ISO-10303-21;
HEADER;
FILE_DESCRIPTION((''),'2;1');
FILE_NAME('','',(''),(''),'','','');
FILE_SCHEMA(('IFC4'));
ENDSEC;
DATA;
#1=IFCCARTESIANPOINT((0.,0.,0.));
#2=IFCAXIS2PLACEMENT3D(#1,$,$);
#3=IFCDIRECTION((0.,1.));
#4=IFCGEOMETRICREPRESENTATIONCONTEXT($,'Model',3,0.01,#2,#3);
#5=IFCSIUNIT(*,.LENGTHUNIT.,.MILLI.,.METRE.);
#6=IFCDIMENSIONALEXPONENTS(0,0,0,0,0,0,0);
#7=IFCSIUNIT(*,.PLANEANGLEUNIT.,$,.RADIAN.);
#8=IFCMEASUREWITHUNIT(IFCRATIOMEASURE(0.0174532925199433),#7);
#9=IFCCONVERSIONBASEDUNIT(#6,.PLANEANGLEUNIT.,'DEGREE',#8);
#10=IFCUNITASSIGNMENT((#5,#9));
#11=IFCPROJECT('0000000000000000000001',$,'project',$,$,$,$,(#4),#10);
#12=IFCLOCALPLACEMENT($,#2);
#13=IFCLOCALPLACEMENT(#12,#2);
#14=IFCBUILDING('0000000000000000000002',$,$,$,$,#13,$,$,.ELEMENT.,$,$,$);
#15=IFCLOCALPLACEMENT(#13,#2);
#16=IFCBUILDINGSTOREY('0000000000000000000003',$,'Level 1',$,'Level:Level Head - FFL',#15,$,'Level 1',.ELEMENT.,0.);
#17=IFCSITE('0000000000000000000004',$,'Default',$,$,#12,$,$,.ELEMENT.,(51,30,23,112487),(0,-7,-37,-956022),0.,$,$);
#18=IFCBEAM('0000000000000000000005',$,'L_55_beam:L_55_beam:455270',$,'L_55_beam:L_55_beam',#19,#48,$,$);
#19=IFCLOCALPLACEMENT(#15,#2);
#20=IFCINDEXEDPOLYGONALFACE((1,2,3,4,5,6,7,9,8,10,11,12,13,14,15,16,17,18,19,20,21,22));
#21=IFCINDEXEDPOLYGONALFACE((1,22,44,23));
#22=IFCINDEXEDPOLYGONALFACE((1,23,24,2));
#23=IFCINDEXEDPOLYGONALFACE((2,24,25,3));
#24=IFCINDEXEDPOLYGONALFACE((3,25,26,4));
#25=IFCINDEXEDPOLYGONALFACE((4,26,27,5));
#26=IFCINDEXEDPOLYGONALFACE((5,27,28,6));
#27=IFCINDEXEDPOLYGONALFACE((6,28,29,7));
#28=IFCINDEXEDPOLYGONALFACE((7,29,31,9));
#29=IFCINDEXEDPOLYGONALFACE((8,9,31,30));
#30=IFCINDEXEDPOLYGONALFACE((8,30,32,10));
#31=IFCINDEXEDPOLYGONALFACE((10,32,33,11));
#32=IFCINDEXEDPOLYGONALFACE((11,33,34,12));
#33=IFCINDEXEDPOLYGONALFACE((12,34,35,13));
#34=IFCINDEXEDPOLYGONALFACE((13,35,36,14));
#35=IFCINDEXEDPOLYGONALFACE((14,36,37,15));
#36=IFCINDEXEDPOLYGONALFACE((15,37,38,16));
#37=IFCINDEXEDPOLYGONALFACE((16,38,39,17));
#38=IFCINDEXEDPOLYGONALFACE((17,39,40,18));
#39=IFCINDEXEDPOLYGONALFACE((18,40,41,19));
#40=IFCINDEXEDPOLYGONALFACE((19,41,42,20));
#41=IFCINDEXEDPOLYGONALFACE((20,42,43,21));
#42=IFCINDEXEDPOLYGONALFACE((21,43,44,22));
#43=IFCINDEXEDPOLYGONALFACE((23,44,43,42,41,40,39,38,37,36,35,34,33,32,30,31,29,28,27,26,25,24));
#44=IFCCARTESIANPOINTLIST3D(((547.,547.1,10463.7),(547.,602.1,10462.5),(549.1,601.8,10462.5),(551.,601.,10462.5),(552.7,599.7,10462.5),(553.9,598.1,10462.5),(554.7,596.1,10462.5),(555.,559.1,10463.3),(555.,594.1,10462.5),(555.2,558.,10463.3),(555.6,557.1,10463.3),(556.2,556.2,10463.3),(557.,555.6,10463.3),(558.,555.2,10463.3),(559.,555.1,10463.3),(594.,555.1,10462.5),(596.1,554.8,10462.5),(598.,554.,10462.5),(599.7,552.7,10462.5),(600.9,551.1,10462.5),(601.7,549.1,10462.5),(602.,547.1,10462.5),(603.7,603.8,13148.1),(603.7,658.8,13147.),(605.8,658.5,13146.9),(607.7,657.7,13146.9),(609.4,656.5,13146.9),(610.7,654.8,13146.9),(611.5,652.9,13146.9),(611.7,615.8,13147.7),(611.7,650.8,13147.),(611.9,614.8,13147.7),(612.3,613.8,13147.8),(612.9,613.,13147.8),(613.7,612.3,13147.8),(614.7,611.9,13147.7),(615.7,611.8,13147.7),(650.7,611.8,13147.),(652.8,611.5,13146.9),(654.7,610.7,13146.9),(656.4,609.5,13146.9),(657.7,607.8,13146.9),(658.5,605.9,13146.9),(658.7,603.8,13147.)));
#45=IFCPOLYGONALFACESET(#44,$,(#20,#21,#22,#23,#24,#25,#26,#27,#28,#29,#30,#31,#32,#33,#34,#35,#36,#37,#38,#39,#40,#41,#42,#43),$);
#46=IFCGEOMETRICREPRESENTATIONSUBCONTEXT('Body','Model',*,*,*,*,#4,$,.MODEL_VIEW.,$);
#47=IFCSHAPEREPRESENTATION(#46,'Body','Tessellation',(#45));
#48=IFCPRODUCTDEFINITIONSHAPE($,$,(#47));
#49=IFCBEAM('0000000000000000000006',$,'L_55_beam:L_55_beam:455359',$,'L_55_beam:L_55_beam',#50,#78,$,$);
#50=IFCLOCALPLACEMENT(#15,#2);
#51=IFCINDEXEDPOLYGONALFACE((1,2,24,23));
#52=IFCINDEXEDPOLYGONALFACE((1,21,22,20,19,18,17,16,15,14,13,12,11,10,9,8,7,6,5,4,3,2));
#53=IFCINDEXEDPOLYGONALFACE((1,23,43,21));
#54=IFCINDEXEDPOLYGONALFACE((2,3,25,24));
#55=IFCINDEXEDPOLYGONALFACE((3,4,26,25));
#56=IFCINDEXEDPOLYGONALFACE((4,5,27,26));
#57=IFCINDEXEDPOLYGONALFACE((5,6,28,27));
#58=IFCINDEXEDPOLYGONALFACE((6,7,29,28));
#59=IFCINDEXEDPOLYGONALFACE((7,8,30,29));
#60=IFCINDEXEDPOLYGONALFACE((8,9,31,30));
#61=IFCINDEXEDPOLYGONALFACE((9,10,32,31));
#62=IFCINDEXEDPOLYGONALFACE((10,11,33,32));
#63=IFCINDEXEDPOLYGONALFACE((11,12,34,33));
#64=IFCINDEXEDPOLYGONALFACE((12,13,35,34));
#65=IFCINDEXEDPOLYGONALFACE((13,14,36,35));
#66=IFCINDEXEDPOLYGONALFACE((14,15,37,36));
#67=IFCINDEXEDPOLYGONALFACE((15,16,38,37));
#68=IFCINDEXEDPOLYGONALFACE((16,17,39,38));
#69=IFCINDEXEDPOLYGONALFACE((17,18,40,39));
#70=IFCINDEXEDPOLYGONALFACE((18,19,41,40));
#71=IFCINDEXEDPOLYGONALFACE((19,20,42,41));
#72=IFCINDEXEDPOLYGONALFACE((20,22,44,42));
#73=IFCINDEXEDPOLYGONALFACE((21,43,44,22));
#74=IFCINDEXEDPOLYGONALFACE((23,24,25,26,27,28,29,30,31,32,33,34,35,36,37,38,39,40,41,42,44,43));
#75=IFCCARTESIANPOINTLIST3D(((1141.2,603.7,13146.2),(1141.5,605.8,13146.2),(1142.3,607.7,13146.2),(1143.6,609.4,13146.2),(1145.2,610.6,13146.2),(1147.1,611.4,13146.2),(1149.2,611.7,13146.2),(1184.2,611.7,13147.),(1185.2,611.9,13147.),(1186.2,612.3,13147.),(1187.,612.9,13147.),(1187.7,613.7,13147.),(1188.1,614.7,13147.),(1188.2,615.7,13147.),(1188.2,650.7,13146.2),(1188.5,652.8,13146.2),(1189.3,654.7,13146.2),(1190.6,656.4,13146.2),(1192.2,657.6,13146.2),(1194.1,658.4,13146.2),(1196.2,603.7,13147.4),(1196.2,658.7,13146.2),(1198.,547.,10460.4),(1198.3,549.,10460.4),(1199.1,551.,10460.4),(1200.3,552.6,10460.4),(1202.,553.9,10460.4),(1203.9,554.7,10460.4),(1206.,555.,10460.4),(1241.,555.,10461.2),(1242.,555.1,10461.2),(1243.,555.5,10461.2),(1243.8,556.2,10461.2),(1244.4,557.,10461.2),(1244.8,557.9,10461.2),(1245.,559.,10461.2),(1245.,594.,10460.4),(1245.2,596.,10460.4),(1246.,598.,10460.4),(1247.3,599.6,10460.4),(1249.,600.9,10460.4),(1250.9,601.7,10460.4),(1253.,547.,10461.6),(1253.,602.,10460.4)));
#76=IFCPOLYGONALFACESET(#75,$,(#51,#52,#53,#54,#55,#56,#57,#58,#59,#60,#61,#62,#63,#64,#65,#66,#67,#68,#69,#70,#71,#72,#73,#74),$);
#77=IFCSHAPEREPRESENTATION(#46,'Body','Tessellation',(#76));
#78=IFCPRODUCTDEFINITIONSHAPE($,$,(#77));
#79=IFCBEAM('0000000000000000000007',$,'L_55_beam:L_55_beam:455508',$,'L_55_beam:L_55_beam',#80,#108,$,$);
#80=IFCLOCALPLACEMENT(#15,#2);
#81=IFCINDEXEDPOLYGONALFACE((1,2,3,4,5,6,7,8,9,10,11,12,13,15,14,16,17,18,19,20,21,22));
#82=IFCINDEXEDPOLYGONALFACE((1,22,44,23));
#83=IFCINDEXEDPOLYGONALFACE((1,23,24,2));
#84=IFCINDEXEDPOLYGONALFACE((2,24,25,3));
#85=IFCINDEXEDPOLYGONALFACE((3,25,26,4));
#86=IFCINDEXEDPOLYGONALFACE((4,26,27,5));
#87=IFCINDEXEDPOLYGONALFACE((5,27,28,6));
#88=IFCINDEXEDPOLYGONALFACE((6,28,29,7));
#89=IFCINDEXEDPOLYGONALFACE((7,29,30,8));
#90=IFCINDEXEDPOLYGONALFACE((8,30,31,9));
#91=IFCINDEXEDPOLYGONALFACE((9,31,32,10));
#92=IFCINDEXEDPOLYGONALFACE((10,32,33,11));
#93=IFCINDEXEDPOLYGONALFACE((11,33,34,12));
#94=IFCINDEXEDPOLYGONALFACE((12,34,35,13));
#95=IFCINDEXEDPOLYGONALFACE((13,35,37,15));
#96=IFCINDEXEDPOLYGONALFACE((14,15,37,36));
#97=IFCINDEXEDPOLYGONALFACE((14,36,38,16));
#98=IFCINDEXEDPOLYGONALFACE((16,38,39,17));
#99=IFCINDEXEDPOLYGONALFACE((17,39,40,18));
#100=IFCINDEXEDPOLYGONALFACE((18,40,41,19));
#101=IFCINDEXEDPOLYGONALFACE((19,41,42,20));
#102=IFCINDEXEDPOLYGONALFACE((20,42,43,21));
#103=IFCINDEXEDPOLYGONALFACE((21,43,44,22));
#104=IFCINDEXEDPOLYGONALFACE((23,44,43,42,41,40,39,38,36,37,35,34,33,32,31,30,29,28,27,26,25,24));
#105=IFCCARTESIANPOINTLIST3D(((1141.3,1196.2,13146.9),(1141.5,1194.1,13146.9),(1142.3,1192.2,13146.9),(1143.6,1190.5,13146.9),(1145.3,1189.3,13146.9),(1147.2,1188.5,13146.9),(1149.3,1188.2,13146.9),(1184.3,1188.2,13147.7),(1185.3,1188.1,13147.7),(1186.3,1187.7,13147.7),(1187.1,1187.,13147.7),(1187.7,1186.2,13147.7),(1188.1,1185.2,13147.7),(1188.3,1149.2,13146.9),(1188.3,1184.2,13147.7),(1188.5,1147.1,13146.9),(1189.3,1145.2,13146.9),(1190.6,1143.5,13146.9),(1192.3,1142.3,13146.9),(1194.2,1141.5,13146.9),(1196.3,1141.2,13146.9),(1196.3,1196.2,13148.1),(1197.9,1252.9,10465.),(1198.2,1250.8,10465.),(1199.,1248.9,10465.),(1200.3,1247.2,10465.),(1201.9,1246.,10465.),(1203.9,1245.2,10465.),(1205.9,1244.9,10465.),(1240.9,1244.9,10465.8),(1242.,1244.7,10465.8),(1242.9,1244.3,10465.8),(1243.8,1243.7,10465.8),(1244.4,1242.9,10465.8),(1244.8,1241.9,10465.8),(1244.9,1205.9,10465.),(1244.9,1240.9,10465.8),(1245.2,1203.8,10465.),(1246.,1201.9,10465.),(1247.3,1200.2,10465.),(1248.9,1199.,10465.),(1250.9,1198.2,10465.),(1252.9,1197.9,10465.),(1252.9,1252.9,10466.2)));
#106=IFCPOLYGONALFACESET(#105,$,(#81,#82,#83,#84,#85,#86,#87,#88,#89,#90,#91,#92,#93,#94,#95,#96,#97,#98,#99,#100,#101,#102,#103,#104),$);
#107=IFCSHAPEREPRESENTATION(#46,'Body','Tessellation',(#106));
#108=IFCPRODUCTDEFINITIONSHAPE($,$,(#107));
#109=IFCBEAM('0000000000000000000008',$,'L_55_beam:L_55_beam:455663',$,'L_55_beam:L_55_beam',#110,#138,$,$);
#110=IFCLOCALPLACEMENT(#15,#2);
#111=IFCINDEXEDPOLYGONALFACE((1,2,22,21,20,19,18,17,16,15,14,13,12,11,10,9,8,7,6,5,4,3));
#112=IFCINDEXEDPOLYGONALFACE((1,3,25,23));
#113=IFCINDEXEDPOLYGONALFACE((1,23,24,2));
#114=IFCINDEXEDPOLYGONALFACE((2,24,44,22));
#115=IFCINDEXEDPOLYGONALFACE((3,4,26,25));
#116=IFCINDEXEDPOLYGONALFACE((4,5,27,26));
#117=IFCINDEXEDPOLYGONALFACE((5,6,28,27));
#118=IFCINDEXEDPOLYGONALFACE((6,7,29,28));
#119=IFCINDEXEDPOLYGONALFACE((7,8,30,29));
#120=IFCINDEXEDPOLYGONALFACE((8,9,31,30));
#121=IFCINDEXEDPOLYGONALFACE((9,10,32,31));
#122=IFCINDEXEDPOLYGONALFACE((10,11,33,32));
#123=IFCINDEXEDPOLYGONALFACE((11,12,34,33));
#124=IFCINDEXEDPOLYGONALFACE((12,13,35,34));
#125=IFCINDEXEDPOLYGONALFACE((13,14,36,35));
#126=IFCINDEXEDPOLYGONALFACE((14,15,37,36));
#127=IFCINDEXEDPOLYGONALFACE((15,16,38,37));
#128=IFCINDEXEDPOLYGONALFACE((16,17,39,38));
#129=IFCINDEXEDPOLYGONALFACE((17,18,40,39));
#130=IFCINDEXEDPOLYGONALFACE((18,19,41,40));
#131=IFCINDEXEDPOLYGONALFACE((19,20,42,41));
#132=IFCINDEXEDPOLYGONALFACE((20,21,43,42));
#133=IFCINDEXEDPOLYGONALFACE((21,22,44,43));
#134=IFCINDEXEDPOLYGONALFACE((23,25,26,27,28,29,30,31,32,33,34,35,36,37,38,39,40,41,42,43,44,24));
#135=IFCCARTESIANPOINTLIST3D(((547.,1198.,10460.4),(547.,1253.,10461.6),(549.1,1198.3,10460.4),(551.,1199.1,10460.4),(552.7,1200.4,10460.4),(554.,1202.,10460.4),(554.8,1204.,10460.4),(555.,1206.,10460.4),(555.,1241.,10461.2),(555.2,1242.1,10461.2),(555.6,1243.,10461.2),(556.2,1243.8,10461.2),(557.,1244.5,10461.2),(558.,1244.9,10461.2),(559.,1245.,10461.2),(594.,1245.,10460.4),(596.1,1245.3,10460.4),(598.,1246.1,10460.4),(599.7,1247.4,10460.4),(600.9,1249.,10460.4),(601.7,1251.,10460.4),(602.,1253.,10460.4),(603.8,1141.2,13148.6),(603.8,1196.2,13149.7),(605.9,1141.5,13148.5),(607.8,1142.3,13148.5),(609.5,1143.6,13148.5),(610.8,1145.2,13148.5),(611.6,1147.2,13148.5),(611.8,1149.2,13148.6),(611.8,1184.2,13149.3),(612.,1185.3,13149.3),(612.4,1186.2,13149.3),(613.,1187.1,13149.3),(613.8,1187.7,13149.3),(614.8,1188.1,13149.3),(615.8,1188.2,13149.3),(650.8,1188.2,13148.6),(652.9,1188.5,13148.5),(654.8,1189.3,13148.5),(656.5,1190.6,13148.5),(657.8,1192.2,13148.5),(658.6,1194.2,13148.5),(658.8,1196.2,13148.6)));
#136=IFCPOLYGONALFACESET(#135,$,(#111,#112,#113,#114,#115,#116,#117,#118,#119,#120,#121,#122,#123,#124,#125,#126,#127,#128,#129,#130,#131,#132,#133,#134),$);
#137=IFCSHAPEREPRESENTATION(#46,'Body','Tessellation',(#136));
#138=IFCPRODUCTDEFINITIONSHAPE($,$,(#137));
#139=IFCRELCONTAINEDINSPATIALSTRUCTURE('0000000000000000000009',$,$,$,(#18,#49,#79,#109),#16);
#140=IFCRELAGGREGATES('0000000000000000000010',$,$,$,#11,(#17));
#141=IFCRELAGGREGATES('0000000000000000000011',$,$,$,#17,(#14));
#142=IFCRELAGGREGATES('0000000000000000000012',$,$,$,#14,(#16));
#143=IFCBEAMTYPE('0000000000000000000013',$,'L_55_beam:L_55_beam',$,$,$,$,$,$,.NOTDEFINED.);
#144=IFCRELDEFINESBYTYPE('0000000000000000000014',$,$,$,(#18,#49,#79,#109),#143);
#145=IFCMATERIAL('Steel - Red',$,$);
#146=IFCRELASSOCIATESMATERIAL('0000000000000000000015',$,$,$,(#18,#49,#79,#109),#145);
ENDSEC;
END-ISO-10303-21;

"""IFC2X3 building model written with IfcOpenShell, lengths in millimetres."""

from ifc_helpers import new_model, entity, si_unit, converted_unit, direction, frame, frame_2d, origin, place, context, subcontext, project, spatial, polyline, circle_curve, parameter, trimmed, segment, composite_curve, outline, extrude, material, type_object, element, save


model = new_model("IFC2X3")

# Units and contexts
model_context = context("Model", 3, precision=0.01, world=origin(), true_north=direction((0.0, 1.0)))
body_context = subcontext(model_context, "Body", "Model", "MODEL_VIEW")
ifc_project = project(units=[si_unit("LENGTHUNIT", "METRE", prefix="MILLI"), converted_unit("PLANEANGLEUNIT", "DEGREE", entity("IfcRatioMeasure", 0.0174532925199433), si_unit("PLANEANGLEUNIT", "RADIAN"), dimensions=[0, 0, 0, 0, 0, 0, 0])], contexts=[model_context])

# Site, building, storey
site_placement = place(None, origin())
site = spatial("IfcSite", under=ifc_project, at=site_placement, Name="Default", CompositionType="ELEMENT", RefLatitude=(51, 30, 23, 112487), RefLongitude=(0, -7, -37, -956022), RefElevation=0.0)
building_placement = place(site_placement, origin())
building = spatial("IfcBuilding", under=site, at=building_placement, CompositionType="ELEMENT")
storey_placement = place(building_placement, origin())
storey = spatial("IfcBuildingStorey", under=building, at=storey_placement, Name="Level 1", ObjectType="Level:Level Head - FFL", LongName="Level 1", CompositionType="ELEMENT", Elevation=0.0)

# Beams
ifc_material_1 = material(Name="Steel - Red")
beam_type_1 = type_object("IfcBeamType", Name="L_55_beam:L_55_beam", PredefinedType="NOTDEFINED")
beam_1_placement = place(storey_placement, frame((603.7, 603.8, 13148.1), z_axis=(0.999777, -0.000446, -0.021115), x_axis=(-0.02112, -0.021125, -0.999554)))
element("IfcBeam", 1, at=beam_1_placement, inside=storey, type_object=beam_type_1, material=ifc_material_1, Name="L_55_beam:L_55_beam:455270", ObjectType="L_55_beam:L_55_beam", context=body_context, shape_type="SweptSolid", body=[
    extrude(outline(composite_curve([segment(polyline([(-6.6, 10.6), (28.4, 10.6)]), True, "CONTINUOUS"), segment(trimmed(circle_curve(frame_2d((28.4, 18.6), x_axis=(0.0, -1.0)), 8.0), [parameter(0.0)], [parameter(90.0)], True, "PARAMETER"), True, "CONTINUOUS"), segment(polyline([(36.4, 18.6), (-18.6, 18.6)]), True, "CONTINUOUS"), segment(polyline([(-18.6, 18.6), (-18.6, -36.4)]), True, "CONTINUOUS"), segment(trimmed(circle_curve(frame_2d((-18.6, -28.4), x_axis=(0.0, -1.0)), 8.0), [parameter(0.0)], [parameter(90.0)], True, "PARAMETER"), True, "CONTINUOUS"), segment(polyline([(-10.6, -28.4), (-10.6, 6.6)]), True, "CONTINUOUS"), segment(trimmed(circle_curve(frame_2d((-6.6, 6.6), x_axis=(-1.0, 0.0)), 4.0), [parameter(270.0)], [parameter(0.0)], True, "PARAMETER"), False, "CONTINUOUS")], self_intersect=False)), frame((0.0, 18.6, 18.6), z_axis=(1.0, 0.0, 0.0), x_axis=(0.0, 0.000332, 1.0)), (0.0, 0.0, 1.0), 2685.7),
])
beam_2_placement = place(storey_placement, frame((1196.2, 603.7, 13147.4), z_axis=(0.999777, 0.000446, 0.02112), x_axis=(0.021125, -0.02112, -0.999554)))
element("IfcBeam", 2, at=beam_2_placement, inside=storey, type_object=beam_type_1, material=ifc_material_1, Name="L_55_beam:L_55_beam:455359", ObjectType="L_55_beam:L_55_beam", context=body_context, shape_type="SweptSolid", body=[
    extrude(outline(composite_curve([segment(polyline([(-36.4, -18.6), (18.6, -18.6)]), True, "CONTINUOUS"), segment(polyline([(18.6, -18.6), (18.6, 36.4)]), True, "CONTINUOUS"), segment(trimmed(circle_curve(frame_2d((18.6, 28.4), x_axis=(0.0, 1.0)), 8.0), [parameter(0.0)], [parameter(90.0)], True, "PARAMETER"), True, "CONTINUOUS"), segment(polyline([(10.6, 28.4), (10.6, -6.6)]), True, "CONTINUOUS"), segment(trimmed(circle_curve(frame_2d((6.6, -6.6), x_axis=(1.0, 0.0)), 4.0), [parameter(270.0)], [parameter(0.0)], True, "PARAMETER"), False, "CONTINUOUS"), segment(polyline([(6.6, -10.6), (-28.4, -10.6)]), True, "CONTINUOUS"), segment(trimmed(circle_curve(frame_2d((-28.4, -18.6), x_axis=(0.0, 1.0)), 8.0), [parameter(0.0)], [parameter(90.0)], True, "PARAMETER"), True, "CONTINUOUS")], self_intersect=False)), frame((0.0, 18.6, -18.6), z_axis=(1.0, 0.0, 0.0), x_axis=(0.0, -1.0, -0.000112)), (0.0, 0.0, 1.0), 2687.0),
])
beam_3_placement = place(storey_placement, frame((1196.3, 1196.2, 13148.1), z_axis=(0.999777, -0.000446, 0.021115), x_axis=(0.02112, 0.021125, -0.999554)))
element("IfcBeam", 3, at=beam_3_placement, inside=storey, type_object=beam_type_1, material=ifc_material_1, Name="L_55_beam:L_55_beam:455508", ObjectType="L_55_beam:L_55_beam", context=body_context, shape_type="SweptSolid", body=[
    extrude(outline(composite_curve([segment(polyline([(-36.4, -18.6), (18.6, -18.6)]), True, "CONTINUOUS"), segment(polyline([(18.6, -18.6), (18.6, 36.4)]), True, "CONTINUOUS"), segment(trimmed(circle_curve(frame_2d((18.6, 28.4), x_axis=(0.0, 1.0)), 8.0), [parameter(0.0)], [parameter(90.0)], True, "PARAMETER"), True, "CONTINUOUS"), segment(polyline([(10.6, 28.4), (10.6, -6.6)]), True, "CONTINUOUS"), segment(trimmed(circle_curve(frame_2d((6.6, -6.6), x_axis=(1.0, 0.0)), 4.0), [parameter(270.0)], [parameter(0.0)], True, "PARAMETER"), False, "CONTINUOUS"), segment(polyline([(6.6, -10.6), (-28.4, -10.6)]), True, "CONTINUOUS"), segment(trimmed(circle_curve(frame_2d((-28.4, -18.6), x_axis=(0.0, 1.0)), 8.0), [parameter(0.0)], [parameter(90.0)], True, "PARAMETER"), True, "CONTINUOUS")], self_intersect=False)), frame((0.0, -18.6, -18.6), z_axis=(1.0, 0.0, 0.0), x_axis=(0.0, 0.000332, 1.0)), (0.0, 0.0, 1.0), 2683.1),
])
beam_4_placement = place(storey_placement, frame((603.8, 1196.2, 13149.7), z_axis=(0.999777, 0.000446, -0.02112), x_axis=(-0.021125, 0.02112, -0.999554)))
element("IfcBeam", 4, at=beam_4_placement, inside=storey, type_object=beam_type_1, material=ifc_material_1, Name="L_55_beam:L_55_beam:455663", ObjectType="L_55_beam:L_55_beam", context=body_context, shape_type="SweptSolid", body=[
    extrude(outline(composite_curve([segment(polyline([(-18.6, -18.6), (36.4, -18.6)]), True, "CONTINUOUS"), segment(trimmed(circle_curve(frame_2d((28.4, -18.6), x_axis=(1.0, 0.0)), 8.0), [parameter(0.0)], [parameter(90.0)], True, "PARAMETER"), True, "CONTINUOUS"), segment(polyline([(28.4, -10.6), (-6.6, -10.6)]), True, "CONTINUOUS"), segment(trimmed(circle_curve(frame_2d((-6.6, -6.6), x_axis=(0.0, -1.0)), 4.0), [parameter(270.0)], [parameter(0.0)], True, "PARAMETER"), False, "CONTINUOUS"), segment(polyline([(-10.6, -6.6), (-10.6, 28.4)]), True, "CONTINUOUS"), segment(trimmed(circle_curve(frame_2d((-18.6, 28.4), x_axis=(1.0, 0.0)), 8.0), [parameter(0.0)], [parameter(90.0)], True, "PARAMETER"), True, "CONTINUOUS"), segment(polyline([(-18.6, 36.4), (-18.6, -18.6)]), True, "CONTINUOUS")], self_intersect=False)), frame((0.0, -18.6, 18.6), z_axis=(1.0, 0.0, 0.0), x_axis=(0.0, -0.000112, 1.0)), (0.0, 0.0, 1.0), 2689.3),
])

save(model, "model.ifc")
